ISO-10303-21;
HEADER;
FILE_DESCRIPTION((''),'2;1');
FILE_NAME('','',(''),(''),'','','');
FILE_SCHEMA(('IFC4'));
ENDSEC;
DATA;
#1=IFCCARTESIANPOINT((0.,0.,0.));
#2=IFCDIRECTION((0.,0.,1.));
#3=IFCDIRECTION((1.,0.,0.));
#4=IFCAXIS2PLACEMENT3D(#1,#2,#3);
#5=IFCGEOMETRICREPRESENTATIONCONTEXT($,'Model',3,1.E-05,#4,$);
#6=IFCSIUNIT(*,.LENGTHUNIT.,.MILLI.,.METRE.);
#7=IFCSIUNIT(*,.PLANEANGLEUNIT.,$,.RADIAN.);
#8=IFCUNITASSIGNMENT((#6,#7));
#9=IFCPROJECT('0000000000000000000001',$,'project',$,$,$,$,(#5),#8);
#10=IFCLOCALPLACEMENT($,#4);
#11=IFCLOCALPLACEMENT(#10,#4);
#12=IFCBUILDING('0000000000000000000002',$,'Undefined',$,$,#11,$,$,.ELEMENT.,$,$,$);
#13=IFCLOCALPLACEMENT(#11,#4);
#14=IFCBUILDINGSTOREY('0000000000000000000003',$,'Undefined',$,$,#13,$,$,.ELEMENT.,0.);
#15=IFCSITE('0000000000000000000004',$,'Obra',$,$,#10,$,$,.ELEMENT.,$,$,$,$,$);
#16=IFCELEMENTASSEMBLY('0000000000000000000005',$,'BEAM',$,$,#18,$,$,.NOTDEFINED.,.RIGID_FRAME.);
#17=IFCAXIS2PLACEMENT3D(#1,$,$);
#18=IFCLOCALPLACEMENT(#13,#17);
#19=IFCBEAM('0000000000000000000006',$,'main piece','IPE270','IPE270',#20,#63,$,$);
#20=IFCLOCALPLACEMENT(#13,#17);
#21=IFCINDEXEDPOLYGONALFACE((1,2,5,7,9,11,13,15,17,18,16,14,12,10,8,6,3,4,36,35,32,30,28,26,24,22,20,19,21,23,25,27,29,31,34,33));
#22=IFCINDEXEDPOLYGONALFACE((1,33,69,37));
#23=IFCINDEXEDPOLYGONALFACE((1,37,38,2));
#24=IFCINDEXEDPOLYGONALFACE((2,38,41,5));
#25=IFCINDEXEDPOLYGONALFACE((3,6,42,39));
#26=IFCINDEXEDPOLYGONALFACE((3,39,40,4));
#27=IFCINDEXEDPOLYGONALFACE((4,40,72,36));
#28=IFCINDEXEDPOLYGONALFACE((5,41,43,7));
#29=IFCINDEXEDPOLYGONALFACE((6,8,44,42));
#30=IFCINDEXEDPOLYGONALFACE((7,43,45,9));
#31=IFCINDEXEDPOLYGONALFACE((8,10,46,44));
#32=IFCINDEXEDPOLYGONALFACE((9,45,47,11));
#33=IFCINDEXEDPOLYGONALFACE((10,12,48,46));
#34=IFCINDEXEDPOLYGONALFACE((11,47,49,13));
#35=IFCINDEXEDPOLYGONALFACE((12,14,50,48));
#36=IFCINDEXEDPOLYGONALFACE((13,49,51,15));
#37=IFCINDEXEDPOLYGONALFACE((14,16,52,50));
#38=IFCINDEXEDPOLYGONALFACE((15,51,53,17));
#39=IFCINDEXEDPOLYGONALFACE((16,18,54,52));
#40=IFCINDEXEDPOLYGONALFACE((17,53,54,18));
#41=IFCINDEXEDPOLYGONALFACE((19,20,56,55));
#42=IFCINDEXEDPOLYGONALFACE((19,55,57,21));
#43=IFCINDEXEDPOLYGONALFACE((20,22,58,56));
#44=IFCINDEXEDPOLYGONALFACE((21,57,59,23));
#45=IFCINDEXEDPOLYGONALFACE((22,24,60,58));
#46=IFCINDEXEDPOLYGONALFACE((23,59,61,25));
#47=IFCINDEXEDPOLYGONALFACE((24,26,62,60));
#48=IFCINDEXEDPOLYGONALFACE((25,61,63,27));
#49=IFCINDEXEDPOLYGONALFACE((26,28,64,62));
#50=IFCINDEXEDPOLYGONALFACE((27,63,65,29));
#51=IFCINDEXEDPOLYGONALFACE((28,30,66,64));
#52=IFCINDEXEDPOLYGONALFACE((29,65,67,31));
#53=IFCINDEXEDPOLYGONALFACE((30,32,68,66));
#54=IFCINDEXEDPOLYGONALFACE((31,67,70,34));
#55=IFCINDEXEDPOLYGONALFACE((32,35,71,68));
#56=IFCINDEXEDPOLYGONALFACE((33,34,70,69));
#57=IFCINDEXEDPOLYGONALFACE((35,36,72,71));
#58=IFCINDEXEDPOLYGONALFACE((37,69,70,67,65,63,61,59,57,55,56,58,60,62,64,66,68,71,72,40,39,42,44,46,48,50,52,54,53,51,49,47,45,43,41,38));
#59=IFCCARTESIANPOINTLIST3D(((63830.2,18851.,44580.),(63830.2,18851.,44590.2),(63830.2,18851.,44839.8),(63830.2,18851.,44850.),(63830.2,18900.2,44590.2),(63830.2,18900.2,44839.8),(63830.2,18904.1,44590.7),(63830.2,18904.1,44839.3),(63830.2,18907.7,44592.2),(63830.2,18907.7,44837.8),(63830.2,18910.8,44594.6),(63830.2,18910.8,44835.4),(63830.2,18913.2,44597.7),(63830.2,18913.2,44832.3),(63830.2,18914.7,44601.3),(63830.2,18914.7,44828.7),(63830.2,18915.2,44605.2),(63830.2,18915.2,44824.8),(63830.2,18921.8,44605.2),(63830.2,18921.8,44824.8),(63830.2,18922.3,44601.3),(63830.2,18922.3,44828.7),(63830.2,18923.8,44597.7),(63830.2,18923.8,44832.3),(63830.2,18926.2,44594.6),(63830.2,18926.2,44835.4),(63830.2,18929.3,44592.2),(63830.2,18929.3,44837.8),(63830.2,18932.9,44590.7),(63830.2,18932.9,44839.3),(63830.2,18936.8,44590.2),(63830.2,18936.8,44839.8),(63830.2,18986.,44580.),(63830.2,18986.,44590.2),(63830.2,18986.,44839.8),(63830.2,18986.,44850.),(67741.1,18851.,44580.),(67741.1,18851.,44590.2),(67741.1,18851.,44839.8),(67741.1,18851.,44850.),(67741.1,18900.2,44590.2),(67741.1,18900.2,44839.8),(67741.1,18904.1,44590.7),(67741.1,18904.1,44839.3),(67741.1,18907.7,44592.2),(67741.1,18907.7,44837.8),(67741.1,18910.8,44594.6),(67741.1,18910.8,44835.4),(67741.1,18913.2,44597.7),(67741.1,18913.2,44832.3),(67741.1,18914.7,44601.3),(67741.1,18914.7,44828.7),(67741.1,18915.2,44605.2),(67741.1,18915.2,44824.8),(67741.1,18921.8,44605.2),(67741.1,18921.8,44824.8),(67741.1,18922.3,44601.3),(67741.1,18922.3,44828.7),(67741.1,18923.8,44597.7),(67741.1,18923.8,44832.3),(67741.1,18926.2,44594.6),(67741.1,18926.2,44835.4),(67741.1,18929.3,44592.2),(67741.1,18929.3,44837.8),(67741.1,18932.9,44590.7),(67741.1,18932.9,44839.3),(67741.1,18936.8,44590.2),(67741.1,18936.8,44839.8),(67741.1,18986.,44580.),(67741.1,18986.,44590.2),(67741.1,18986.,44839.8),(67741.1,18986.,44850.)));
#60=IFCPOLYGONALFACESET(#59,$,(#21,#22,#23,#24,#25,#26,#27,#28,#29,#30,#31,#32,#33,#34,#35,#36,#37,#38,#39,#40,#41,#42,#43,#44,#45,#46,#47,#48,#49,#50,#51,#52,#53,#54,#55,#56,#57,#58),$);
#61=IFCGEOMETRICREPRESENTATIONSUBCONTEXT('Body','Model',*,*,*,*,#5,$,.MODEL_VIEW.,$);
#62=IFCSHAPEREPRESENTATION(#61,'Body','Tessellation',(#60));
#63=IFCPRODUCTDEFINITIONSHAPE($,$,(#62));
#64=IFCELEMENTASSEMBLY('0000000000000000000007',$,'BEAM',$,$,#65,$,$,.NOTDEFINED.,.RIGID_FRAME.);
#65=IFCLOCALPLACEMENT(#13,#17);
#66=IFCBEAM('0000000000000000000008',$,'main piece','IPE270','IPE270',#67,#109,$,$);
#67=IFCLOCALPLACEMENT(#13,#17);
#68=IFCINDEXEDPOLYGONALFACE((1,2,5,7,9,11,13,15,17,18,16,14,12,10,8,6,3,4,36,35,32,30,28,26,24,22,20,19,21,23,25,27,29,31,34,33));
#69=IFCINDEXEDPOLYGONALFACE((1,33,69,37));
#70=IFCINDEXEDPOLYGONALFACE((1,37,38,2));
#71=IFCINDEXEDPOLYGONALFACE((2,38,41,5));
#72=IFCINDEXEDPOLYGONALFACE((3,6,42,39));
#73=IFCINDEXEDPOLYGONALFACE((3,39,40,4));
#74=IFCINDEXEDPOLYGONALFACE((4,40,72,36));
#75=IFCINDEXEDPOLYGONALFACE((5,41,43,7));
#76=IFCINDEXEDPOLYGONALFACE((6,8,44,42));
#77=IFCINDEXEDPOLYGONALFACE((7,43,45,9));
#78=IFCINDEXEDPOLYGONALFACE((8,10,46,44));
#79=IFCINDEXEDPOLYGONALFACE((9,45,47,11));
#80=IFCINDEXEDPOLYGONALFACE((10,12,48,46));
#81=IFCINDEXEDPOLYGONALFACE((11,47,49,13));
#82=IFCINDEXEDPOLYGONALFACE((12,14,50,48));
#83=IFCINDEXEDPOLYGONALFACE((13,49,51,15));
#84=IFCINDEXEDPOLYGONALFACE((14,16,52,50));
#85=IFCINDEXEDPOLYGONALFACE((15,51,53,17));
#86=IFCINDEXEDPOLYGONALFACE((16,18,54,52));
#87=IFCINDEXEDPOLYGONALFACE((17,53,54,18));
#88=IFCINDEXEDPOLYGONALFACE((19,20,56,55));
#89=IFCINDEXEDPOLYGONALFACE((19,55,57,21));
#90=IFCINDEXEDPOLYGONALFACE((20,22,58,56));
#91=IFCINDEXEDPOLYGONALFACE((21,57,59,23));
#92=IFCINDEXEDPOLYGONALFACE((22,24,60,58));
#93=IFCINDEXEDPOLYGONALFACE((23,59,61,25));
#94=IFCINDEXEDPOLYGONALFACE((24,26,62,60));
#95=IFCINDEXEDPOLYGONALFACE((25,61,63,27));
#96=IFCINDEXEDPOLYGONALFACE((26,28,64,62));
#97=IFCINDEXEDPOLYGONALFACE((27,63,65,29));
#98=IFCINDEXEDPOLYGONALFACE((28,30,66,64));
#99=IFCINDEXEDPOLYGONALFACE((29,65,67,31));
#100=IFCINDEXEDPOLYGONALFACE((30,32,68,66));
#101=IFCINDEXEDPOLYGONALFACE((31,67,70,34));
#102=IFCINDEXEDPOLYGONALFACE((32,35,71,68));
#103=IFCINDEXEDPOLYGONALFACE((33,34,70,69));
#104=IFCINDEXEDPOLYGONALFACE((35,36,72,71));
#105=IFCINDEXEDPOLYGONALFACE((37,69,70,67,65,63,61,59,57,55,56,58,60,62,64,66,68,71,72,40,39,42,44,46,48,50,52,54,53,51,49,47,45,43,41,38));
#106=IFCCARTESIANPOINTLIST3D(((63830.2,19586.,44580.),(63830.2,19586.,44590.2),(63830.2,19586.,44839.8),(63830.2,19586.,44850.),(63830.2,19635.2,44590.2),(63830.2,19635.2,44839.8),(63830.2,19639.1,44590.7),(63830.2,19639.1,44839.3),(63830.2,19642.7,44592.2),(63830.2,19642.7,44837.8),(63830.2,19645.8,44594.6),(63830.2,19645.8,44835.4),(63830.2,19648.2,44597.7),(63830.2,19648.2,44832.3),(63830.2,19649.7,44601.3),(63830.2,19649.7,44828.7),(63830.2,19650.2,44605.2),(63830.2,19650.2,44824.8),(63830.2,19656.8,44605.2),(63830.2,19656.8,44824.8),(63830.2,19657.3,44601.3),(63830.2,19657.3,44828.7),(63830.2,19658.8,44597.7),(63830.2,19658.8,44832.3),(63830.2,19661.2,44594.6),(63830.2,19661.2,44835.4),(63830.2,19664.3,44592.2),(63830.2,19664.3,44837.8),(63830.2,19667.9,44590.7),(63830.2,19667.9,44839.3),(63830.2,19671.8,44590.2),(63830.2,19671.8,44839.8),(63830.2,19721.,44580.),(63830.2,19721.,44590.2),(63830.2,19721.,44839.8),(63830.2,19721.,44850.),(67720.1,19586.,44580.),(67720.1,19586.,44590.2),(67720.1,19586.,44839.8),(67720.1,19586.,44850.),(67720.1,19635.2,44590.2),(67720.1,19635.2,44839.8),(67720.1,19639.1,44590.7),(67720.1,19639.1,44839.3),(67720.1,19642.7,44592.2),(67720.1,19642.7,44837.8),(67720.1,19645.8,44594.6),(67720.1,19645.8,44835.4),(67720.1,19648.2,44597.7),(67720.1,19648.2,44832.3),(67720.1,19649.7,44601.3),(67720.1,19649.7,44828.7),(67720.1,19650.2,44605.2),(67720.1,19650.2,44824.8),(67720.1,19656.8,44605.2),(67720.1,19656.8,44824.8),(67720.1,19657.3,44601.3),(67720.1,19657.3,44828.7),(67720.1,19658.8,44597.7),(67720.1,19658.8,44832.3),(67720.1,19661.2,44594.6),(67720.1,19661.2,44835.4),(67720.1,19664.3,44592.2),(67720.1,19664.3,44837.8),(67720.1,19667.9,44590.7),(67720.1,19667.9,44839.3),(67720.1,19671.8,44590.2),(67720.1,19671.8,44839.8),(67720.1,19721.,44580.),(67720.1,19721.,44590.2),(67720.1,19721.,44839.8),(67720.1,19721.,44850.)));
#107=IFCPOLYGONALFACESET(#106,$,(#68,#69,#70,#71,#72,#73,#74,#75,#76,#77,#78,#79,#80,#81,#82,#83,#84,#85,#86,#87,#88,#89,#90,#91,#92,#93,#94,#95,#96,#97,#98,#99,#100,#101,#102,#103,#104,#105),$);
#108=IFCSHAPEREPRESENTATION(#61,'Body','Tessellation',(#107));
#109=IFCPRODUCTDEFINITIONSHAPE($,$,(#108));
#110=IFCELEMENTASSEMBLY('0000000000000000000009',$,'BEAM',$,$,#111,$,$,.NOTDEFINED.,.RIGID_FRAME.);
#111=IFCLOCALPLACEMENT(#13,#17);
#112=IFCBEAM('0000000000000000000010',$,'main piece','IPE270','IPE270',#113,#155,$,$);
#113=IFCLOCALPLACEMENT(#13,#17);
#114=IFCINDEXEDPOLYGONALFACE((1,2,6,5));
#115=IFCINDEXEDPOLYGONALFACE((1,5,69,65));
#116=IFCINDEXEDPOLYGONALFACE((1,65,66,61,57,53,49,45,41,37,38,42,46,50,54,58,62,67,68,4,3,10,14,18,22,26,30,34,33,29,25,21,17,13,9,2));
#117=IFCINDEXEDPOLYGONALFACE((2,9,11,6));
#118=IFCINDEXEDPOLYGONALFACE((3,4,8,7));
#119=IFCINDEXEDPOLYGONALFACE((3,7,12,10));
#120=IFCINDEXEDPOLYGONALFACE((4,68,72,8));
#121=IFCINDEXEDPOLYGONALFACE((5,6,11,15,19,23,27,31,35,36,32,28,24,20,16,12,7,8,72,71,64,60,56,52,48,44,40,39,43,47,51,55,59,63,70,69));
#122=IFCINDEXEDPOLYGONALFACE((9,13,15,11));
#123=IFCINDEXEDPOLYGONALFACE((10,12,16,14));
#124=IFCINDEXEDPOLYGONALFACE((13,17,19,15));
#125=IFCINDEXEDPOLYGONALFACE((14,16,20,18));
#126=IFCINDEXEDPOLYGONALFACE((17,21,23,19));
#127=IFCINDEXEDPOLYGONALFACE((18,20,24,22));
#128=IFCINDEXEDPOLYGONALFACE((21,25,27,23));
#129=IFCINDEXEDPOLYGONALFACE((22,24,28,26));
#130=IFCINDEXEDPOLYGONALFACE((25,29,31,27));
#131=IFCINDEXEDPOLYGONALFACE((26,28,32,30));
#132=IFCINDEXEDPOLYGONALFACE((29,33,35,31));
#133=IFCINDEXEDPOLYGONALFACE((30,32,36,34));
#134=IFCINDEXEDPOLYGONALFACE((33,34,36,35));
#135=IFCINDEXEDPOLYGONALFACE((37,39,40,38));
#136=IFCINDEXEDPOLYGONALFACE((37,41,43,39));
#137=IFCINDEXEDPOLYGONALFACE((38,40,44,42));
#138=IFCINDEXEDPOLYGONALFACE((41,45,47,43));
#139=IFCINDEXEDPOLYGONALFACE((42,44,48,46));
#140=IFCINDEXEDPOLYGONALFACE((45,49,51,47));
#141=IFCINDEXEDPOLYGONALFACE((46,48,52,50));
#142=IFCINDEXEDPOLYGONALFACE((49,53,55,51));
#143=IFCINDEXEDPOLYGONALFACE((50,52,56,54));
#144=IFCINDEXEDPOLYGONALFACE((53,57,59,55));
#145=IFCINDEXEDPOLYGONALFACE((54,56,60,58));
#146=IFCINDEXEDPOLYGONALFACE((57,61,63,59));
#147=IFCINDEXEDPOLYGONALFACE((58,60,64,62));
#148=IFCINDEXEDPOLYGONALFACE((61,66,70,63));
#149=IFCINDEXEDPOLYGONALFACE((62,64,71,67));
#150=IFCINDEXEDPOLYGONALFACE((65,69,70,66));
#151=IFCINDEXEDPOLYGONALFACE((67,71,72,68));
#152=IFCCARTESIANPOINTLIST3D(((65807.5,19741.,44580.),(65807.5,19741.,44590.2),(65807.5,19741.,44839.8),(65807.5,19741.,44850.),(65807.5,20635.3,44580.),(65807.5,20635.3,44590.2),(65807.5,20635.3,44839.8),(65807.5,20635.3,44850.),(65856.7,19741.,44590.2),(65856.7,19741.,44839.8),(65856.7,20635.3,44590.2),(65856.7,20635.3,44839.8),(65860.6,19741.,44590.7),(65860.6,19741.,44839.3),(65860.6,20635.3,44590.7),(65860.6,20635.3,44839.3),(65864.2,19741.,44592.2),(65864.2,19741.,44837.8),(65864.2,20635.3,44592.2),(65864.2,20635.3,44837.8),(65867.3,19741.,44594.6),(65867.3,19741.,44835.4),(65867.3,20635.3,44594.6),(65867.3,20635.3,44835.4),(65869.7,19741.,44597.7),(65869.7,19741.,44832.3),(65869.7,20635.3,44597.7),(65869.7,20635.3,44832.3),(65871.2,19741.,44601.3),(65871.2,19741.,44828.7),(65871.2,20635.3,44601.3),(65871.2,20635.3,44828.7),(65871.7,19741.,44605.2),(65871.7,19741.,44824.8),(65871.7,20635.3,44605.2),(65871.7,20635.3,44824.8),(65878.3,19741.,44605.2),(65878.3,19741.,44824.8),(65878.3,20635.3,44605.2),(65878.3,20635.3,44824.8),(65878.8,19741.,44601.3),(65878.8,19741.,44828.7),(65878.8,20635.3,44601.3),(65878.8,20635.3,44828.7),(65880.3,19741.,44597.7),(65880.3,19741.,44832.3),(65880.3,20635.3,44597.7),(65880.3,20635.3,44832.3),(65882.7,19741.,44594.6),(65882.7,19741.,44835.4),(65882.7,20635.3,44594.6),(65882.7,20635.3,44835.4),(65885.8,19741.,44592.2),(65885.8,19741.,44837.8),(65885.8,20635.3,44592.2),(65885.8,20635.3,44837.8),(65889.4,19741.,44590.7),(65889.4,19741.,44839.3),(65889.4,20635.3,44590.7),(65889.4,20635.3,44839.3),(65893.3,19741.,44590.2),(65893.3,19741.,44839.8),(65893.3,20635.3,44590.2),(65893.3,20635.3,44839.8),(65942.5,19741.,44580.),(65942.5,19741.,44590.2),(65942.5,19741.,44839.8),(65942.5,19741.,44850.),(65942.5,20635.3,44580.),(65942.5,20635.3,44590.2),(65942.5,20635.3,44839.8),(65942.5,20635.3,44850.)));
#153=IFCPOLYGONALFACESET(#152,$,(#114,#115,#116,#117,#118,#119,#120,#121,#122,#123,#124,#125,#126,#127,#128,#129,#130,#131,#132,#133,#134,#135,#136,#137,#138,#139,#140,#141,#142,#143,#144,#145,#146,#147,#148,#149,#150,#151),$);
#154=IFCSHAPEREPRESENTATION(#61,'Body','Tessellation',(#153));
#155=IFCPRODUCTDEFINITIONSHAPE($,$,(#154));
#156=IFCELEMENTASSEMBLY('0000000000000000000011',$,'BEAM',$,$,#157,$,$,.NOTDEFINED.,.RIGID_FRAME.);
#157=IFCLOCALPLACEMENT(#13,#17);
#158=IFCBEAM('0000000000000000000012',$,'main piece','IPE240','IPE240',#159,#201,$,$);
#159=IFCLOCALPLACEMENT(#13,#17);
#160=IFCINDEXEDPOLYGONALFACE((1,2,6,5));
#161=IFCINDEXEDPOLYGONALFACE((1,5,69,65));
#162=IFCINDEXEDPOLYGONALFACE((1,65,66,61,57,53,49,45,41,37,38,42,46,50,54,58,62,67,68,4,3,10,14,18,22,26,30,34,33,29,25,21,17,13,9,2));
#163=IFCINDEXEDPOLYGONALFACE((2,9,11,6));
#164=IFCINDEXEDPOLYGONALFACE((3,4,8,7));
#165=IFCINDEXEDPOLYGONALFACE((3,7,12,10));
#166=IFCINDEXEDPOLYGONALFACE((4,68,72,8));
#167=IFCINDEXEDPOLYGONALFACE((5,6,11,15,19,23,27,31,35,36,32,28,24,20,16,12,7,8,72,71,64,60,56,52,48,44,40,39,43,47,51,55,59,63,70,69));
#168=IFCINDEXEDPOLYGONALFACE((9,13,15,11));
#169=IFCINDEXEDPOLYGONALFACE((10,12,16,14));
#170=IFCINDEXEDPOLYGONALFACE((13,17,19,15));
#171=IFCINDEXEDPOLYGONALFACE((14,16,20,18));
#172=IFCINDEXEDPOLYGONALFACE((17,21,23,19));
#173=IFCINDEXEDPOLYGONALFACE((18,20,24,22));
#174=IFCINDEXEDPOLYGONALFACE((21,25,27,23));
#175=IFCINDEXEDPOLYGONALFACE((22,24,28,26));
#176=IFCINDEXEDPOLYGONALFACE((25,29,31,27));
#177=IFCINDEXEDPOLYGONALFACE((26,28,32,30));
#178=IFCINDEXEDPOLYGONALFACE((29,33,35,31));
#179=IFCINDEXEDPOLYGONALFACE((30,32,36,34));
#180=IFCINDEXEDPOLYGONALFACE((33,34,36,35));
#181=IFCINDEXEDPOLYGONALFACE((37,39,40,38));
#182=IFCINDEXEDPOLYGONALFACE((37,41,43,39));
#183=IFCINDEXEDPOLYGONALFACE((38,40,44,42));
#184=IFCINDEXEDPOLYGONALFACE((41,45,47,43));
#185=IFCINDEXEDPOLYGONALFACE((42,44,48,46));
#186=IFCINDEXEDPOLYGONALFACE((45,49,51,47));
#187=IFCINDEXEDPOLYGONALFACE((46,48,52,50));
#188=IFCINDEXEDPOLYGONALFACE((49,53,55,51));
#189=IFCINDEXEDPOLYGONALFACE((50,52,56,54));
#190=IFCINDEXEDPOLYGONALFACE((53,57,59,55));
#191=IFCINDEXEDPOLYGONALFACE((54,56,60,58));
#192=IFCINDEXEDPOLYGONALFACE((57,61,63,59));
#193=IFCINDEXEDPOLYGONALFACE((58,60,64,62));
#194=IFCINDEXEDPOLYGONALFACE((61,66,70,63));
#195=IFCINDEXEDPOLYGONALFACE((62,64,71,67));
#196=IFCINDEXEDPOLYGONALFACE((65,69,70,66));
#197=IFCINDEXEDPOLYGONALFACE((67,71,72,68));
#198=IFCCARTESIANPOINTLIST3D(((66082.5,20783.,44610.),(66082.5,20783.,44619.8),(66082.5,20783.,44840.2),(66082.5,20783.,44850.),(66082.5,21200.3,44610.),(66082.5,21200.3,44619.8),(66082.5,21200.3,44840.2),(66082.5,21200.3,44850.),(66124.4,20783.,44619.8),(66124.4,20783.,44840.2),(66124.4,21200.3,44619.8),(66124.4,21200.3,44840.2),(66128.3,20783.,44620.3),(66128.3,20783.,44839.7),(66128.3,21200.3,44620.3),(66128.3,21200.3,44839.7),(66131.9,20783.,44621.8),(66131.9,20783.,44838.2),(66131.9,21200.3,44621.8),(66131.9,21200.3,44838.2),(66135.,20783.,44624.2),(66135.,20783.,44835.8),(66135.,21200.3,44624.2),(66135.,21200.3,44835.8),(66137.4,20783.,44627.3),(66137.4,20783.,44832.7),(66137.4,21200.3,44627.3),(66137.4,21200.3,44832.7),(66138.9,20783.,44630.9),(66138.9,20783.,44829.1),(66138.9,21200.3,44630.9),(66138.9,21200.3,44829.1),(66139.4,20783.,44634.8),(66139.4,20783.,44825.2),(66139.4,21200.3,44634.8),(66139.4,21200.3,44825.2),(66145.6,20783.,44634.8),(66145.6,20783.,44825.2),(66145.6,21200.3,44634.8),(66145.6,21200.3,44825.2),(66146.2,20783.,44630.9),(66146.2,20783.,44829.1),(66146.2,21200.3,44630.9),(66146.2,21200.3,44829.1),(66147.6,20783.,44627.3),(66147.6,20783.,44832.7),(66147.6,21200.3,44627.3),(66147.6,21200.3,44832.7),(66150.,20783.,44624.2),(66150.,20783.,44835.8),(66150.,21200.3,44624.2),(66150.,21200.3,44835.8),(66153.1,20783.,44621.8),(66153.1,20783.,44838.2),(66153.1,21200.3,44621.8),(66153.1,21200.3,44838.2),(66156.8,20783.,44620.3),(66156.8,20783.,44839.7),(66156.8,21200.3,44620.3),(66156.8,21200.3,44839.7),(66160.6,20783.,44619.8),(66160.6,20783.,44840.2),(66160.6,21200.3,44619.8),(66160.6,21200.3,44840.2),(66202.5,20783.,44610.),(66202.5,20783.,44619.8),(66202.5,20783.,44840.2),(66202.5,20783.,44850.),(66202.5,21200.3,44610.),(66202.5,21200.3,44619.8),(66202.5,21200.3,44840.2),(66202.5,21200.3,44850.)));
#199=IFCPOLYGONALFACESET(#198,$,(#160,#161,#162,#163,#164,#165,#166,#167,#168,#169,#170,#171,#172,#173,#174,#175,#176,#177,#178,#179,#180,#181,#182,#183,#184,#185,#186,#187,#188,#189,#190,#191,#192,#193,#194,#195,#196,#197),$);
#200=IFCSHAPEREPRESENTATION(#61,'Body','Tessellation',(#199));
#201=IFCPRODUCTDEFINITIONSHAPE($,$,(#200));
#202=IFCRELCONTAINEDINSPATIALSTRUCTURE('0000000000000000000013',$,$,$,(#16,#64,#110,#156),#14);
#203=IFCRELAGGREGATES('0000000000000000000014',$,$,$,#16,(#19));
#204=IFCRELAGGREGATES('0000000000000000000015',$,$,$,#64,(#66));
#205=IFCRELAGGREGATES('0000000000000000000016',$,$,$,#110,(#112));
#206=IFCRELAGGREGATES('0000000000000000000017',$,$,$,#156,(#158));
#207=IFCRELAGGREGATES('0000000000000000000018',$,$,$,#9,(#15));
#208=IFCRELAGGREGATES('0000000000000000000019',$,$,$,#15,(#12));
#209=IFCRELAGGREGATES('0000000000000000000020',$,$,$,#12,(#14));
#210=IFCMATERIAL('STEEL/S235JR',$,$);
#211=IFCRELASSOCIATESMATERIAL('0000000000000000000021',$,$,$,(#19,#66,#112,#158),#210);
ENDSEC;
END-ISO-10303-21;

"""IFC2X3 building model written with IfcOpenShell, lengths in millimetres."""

from ifc_helpers import new_model, si_unit, frame, origin_with_axes, origin_2d_with_axis, place, context, subcontext, project, spatial, i_section, extrude, material, element, aggregate, save


model = new_model("IFC2X3")

# Units and contexts
model_context = context("Model", 3, precision=1e-05, world=origin_with_axes())
body_context = subcontext(model_context, "Body", "Model", "MODEL_VIEW")
ifc_project = project(units=[si_unit("LENGTHUNIT", "METRE", prefix="MILLI"), si_unit("PLANEANGLEUNIT", "RADIAN")], contexts=[model_context])

# Site, building, storey
site_placement = place(None, origin_with_axes())
site = spatial("IfcSite", under=ifc_project, at=site_placement, Name="Obra", CompositionType="ELEMENT")
building_placement = place(site_placement, origin_with_axes())
building = spatial("IfcBuilding", under=site, at=building_placement, Name="Undefined", CompositionType="ELEMENT")
storey_placement = place(building_placement, origin_with_axes())
storey = spatial("IfcBuildingStorey", under=building, at=storey_placement, Name="Undefined", CompositionType="ELEMENT", Elevation=0.0)

# Shared definitions
ifc_material_1 = material(Name="STEEL/S235JR")

# Element assemblies, beams
assembly_1_placement = place(storey_placement, origin_with_axes())
assembly_1 = element("IfcElementAssembly", 1, at=assembly_1_placement, inside=storey, Name="BEAM", AssemblyPlace="NOTDEFINED", PredefinedType="RIGID_FRAME")
beam_1_placement = place(assembly_1_placement, frame((63830.2, 18918.5, 44715.0), z_axis=(0.0, 0.0, 1.0), x_axis=(1.0, 0.000002, 0.0)))
beam_1 = element("IfcBeam", 2, at=beam_1_placement, material=ifc_material_1, Name="main piece", Description="IPE270", ObjectType="IPE270", context=body_context, shape_type="SweptSolid", body=[
    extrude(i_section(OverallWidth=135.0, OverallDepth=270.0, WebThickness=6.6, FlangeThickness=10.2, FilletRadius=15.0, at=origin_2d_with_axis()), frame((3910.9, 0.0, 0.0), z_axis=(-1.0, 0.0, 0.0), x_axis=(0.0, -1.0, 0.0)), (0.0, 0.0, 1.0), 3910.9),
])
aggregate(assembly_1, [beam_1])
assembly_2_placement = place(storey_placement, origin_with_axes())
assembly_2 = element("IfcElementAssembly", 3, at=assembly_2_placement, inside=storey, Name="BEAM", AssemblyPlace="NOTDEFINED", PredefinedType="RIGID_FRAME")
beam_2_placement = place(assembly_2_placement, frame((63830.2, 19653.5, 44715.0), z_axis=(0.0, 0.0, 1.0), x_axis=(1.0, 0.000002, 0.0)))
beam_2 = element("IfcBeam", 4, at=beam_2_placement, material=ifc_material_1, Name="main piece", Description="IPE270", ObjectType="IPE270", context=body_context, shape_type="SweptSolid", body=[
    extrude(i_section(OverallWidth=135.0, OverallDepth=270.0, WebThickness=6.6, FlangeThickness=10.2, FilletRadius=15.0, at=origin_2d_with_axis()), frame((3889.9, 0.0, 0.0), z_axis=(-1.0, 0.0, 0.0), x_axis=(0.0, -1.0, 0.0)), (0.0, 0.0, 1.0), 3889.9),
])
aggregate(assembly_2, [beam_2])
assembly_3_placement = place(storey_placement, origin_with_axes())
assembly_3 = element("IfcElementAssembly", 5, at=assembly_3_placement, inside=storey, Name="BEAM", AssemblyPlace="NOTDEFINED", PredefinedType="RIGID_FRAME")
beam_3_placement = place(assembly_3_placement, frame((65875.0, 20635.3, 44715.0), z_axis=(0.0, 0.0, 1.0), x_axis=(0.0, -1.0, 0.0)))
beam_3 = element("IfcBeam", 6, at=beam_3_placement, material=ifc_material_1, Name="main piece", Description="IPE270", ObjectType="IPE270", context=body_context, shape_type="SweptSolid", body=[
    extrude(i_section(OverallWidth=135.0, OverallDepth=270.0, WebThickness=6.6, FlangeThickness=10.2, FilletRadius=15.0, at=origin_2d_with_axis()), frame((894.3, 0.0, 0.0), z_axis=(-1.0, 0.0, 0.0), x_axis=(0.0, -1.0, 0.0)), (0.0, 0.0, 1.0), 894.3),
])
aggregate(assembly_3, [beam_3])
assembly_4_placement = place(storey_placement, origin_with_axes())
assembly_4 = element("IfcElementAssembly", 7, at=assembly_4_placement, inside=storey, Name="BEAM", AssemblyPlace="NOTDEFINED", PredefinedType="RIGID_FRAME")
beam_4_placement = place(assembly_4_placement, frame((66142.5, 20783.0, 44730.0), z_axis=(0.0, 0.0, 1.0), x_axis=(0.0, 1.0, 0.0)))
beam_4 = element("IfcBeam", 8, at=beam_4_placement, material=ifc_material_1, Name="main piece", Description="IPE240", ObjectType="IPE240", context=body_context, shape_type="SweptSolid", body=[
    extrude(i_section(OverallWidth=120.0, OverallDepth=240.0, WebThickness=6.2, FlangeThickness=9.8, FilletRadius=15.0, at=origin_2d_with_axis()), frame((417.2, 0.0, 0.0), z_axis=(-1.0, 0.0, 0.0), x_axis=(0.0, -1.0, 0.0)), (0.0, 0.0, 1.0), 417.2),
])
aggregate(assembly_4, [beam_4])

save(model, "model.ifc")
